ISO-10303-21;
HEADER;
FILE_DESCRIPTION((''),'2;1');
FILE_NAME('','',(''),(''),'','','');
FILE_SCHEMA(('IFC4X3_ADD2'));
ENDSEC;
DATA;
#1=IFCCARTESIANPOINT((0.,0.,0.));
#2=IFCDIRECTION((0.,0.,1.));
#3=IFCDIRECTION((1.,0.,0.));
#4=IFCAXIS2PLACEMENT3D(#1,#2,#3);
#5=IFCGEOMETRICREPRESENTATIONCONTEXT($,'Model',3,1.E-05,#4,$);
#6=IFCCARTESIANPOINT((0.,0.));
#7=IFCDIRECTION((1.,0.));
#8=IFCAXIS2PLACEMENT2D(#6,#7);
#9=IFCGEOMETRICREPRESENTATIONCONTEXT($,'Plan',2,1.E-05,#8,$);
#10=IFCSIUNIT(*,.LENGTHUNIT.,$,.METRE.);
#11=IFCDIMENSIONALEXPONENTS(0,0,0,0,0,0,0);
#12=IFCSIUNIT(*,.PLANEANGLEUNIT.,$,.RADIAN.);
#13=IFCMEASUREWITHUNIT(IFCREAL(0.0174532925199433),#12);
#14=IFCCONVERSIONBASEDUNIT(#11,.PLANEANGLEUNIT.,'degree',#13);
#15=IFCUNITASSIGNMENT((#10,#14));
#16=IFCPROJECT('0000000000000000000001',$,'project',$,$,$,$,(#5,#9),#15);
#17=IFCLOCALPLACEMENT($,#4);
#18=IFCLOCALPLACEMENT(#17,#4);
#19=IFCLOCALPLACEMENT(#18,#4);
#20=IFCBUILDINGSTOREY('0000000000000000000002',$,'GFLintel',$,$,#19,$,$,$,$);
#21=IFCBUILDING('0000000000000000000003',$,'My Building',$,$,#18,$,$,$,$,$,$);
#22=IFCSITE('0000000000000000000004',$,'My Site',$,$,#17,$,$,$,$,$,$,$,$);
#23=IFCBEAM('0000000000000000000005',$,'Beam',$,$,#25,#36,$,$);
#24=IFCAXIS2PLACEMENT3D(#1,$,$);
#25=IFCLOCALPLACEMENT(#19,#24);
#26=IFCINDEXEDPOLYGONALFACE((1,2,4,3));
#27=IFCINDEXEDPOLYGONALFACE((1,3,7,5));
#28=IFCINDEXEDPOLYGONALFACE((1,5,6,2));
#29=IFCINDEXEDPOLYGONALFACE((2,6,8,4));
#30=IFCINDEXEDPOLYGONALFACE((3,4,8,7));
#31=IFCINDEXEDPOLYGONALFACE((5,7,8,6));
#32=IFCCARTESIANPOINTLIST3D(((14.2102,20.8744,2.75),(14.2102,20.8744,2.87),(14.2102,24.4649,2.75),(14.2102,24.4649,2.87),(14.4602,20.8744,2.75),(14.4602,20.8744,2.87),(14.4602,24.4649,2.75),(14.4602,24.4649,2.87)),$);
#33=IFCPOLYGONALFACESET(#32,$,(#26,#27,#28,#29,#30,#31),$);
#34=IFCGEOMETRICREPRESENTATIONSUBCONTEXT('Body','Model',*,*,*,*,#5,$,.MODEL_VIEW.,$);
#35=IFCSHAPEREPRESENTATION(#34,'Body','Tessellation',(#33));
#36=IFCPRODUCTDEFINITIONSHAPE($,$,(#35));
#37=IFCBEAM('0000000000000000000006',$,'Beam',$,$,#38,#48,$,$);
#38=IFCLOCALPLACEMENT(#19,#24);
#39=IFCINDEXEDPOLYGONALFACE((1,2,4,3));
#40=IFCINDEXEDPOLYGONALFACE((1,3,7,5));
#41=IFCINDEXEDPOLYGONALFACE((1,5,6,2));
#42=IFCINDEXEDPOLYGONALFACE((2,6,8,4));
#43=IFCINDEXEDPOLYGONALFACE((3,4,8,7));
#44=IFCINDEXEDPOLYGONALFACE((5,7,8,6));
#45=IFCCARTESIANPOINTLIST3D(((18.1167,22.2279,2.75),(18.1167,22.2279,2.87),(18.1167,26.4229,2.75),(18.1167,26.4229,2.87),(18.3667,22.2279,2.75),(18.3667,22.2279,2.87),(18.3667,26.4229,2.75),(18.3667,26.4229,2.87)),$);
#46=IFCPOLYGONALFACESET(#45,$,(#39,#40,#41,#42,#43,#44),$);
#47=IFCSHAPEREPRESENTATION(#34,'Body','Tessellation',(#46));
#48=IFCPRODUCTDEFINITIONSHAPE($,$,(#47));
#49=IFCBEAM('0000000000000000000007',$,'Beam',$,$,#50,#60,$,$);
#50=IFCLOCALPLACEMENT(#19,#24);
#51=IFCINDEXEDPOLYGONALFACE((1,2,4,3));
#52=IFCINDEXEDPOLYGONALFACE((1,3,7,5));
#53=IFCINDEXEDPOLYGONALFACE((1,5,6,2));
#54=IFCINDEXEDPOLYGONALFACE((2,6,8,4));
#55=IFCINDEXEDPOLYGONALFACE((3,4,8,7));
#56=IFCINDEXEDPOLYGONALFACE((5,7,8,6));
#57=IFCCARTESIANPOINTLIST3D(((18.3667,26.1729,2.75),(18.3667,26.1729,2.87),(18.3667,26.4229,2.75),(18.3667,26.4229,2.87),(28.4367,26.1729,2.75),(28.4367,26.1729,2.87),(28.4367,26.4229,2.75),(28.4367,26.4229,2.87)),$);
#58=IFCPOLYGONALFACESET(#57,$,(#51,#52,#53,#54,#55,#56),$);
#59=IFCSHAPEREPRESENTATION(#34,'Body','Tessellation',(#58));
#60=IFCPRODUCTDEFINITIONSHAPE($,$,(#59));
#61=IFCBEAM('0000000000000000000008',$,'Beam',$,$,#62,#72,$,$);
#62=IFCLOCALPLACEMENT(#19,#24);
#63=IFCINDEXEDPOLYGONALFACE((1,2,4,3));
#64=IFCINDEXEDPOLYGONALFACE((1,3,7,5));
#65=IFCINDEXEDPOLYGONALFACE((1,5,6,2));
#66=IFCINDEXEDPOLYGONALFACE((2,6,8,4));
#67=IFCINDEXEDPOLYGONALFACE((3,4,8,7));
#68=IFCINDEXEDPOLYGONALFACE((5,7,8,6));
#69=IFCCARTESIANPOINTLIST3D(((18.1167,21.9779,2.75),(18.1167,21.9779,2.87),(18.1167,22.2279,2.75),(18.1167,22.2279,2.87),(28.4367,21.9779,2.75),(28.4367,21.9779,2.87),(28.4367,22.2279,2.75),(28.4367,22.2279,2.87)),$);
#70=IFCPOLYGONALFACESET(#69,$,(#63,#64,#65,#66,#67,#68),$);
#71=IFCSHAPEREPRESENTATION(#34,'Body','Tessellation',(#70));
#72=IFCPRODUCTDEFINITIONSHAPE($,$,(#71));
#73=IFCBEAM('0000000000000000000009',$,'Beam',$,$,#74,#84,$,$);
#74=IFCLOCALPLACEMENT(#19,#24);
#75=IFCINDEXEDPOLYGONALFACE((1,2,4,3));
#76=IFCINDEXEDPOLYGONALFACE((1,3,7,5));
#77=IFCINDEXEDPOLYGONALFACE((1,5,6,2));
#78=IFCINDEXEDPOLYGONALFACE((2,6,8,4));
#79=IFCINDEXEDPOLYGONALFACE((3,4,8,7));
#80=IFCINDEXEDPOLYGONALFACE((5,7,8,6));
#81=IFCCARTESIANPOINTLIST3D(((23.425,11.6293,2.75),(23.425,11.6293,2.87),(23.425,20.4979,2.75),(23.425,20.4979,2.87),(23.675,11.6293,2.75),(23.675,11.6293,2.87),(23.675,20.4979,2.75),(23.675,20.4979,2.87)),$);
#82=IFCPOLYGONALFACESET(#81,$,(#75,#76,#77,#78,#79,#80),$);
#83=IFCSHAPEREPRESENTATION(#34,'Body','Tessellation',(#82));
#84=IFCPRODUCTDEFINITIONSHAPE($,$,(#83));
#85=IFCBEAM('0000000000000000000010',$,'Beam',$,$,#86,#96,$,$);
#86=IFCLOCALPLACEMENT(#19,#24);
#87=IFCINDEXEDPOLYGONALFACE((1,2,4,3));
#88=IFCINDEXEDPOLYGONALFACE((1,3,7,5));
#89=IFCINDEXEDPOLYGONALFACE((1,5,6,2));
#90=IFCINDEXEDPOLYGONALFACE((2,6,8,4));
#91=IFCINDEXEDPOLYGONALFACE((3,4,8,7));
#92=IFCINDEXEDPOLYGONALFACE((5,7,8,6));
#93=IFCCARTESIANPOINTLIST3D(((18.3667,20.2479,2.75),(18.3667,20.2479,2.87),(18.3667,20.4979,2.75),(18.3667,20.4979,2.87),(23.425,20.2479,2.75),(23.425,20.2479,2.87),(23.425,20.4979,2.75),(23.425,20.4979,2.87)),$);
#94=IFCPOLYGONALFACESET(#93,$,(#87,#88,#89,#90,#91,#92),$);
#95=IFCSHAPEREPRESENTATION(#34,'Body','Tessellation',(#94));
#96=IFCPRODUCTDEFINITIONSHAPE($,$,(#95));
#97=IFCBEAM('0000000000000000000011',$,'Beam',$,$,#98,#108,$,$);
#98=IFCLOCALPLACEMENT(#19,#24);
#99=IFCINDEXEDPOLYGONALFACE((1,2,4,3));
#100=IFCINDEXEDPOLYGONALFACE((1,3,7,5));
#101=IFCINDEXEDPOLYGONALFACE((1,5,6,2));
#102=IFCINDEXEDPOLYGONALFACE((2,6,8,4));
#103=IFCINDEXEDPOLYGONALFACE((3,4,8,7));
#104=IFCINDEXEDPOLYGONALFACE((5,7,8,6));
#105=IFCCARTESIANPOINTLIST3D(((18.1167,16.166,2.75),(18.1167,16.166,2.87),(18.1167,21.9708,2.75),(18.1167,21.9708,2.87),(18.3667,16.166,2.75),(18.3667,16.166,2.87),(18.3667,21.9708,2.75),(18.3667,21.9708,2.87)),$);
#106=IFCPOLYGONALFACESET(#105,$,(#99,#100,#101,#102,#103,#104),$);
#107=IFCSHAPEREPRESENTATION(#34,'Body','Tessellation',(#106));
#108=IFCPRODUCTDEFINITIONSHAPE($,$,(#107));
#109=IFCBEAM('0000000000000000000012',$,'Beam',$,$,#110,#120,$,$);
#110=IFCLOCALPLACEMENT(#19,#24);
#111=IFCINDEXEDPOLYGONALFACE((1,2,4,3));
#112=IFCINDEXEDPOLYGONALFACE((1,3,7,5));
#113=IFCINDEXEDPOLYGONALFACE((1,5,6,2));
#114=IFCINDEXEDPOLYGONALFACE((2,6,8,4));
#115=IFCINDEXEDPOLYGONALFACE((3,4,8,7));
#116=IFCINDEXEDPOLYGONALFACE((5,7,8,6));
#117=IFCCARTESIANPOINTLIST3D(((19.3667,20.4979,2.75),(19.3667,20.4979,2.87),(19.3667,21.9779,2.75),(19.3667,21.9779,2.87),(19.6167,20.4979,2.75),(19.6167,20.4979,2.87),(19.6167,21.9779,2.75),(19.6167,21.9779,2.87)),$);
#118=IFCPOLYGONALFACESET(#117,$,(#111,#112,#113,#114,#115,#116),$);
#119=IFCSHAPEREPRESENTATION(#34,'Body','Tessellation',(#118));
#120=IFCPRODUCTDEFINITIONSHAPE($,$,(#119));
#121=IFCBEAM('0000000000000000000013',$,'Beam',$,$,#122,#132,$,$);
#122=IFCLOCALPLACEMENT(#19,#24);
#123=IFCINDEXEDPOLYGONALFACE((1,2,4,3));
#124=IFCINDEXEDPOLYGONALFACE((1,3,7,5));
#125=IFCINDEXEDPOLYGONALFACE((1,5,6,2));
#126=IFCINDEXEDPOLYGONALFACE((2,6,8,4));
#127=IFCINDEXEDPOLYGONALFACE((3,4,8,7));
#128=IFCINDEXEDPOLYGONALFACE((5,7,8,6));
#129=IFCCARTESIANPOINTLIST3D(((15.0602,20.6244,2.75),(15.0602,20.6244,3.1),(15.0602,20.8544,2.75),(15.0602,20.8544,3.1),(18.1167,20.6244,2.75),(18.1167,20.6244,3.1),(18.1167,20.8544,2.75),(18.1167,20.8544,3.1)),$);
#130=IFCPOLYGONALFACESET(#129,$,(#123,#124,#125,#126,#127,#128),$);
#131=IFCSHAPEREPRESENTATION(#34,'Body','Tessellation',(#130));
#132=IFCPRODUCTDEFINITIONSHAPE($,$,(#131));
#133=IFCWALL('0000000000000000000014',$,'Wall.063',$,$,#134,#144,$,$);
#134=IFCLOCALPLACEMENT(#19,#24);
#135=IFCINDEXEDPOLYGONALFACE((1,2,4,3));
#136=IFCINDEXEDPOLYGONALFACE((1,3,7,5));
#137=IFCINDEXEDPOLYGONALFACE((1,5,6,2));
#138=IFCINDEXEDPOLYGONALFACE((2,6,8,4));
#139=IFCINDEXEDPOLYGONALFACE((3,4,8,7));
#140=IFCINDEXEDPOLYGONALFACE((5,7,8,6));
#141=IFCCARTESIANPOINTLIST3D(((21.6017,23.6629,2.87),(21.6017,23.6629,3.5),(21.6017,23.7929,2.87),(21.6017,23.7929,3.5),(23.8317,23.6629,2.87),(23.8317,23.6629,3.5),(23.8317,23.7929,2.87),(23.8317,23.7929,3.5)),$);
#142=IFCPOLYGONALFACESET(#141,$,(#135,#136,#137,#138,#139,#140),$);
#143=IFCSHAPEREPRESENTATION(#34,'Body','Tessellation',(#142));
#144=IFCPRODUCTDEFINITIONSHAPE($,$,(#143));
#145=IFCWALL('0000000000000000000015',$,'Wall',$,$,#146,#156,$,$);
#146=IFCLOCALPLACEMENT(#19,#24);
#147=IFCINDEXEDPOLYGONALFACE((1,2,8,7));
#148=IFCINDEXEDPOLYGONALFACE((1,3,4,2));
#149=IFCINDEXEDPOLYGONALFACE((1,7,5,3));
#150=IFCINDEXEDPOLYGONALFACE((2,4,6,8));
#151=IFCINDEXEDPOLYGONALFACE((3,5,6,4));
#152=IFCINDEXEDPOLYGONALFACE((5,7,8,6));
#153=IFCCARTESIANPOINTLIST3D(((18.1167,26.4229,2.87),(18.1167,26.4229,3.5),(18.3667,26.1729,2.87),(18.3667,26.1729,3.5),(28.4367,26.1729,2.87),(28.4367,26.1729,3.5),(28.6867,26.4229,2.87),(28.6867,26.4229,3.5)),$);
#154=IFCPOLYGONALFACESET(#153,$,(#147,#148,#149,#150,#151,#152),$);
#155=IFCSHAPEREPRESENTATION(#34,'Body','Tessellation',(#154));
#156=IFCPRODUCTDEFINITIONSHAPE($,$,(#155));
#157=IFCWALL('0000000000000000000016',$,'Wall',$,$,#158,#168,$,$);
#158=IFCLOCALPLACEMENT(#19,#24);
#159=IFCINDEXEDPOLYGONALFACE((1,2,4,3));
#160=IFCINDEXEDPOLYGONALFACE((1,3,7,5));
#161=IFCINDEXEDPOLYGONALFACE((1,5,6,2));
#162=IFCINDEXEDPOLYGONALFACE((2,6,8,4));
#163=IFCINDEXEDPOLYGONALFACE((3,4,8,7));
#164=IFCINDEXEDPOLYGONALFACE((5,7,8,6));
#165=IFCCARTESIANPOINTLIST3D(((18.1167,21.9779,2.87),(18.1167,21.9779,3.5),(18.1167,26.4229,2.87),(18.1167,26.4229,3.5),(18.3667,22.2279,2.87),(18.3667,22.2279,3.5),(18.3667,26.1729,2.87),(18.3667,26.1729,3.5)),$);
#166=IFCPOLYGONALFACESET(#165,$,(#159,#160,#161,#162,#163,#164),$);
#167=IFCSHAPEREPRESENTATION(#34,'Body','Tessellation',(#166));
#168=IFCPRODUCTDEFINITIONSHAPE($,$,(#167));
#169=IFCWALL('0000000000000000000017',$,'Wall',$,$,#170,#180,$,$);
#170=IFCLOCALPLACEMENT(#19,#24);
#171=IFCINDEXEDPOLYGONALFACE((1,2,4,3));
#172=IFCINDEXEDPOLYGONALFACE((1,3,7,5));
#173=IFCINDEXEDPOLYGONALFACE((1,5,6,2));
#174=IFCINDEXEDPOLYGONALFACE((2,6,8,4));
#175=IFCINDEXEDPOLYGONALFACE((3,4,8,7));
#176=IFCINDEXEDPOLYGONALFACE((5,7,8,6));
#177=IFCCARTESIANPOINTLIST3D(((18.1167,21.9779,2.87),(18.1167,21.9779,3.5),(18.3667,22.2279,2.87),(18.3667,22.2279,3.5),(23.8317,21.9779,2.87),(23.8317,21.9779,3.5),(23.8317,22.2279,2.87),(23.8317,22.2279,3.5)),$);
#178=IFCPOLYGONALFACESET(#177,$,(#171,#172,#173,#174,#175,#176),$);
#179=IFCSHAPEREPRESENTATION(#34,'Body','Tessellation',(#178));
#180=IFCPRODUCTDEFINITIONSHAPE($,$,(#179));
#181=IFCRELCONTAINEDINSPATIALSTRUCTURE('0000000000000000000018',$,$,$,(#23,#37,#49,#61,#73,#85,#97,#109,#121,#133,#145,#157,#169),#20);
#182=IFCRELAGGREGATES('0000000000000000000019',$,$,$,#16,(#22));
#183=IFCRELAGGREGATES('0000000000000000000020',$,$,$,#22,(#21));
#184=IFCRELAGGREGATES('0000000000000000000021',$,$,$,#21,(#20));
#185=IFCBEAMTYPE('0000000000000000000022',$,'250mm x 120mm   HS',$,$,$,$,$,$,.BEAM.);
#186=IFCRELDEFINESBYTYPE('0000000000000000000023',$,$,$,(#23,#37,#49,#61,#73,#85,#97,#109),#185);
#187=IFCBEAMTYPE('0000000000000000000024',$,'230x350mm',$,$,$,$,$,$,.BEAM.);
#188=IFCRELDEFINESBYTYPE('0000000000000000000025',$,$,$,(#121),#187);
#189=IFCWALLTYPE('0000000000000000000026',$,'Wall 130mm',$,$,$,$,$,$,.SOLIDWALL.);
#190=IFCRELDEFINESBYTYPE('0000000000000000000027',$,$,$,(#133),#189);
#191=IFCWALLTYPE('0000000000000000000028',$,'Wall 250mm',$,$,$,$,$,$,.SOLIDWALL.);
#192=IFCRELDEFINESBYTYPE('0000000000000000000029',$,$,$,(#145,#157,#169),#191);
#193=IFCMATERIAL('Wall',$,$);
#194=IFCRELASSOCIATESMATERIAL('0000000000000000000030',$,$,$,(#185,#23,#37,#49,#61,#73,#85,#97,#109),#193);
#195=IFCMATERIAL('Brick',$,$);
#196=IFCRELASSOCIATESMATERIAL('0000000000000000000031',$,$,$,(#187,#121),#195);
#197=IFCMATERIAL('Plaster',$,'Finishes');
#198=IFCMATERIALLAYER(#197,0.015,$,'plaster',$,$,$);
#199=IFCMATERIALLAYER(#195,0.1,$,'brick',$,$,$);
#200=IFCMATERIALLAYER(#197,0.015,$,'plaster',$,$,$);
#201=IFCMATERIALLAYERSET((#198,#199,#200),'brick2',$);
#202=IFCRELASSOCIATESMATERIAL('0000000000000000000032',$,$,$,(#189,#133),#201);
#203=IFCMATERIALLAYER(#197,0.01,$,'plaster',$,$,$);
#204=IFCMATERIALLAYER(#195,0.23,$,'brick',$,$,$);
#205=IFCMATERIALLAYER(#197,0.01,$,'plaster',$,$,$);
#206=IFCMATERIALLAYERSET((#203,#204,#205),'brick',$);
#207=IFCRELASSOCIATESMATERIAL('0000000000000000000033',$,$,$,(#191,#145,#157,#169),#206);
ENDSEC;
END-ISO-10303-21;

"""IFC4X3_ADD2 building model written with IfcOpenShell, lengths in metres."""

from ifc_helpers import new_model, entity, si_unit, converted_unit, frame, origin_with_axes, origin_2d_with_axis, place, context, subcontext, project, spatial, line, indexed_curve, rectangle, outline, extrude, material, layer, layer_set, layer_usage, material_profile, profile_set, profile_usage, type_object, element, save


model = new_model("IFC4X3_ADD2")

# Units and contexts
model_context = context("Model", 3, precision=1e-05, world=origin_with_axes())
plan_context = context("Plan", 2, precision=1e-05, world=origin_2d_with_axis())
body_context = subcontext(model_context, "Body", "Model", "MODEL_VIEW")
ifc_project = project(units=[si_unit("LENGTHUNIT", "METRE"), converted_unit("PLANEANGLEUNIT", "degree", entity("IfcReal", 0.0174532925199433), si_unit("PLANEANGLEUNIT", "RADIAN"), dimensions=[0, 0, 0, 0, 0, 0, 0])], contexts=[model_context, plan_context])

# Site, building, storey
site_placement = place(None, origin_with_axes())
site = spatial("IfcSite", under=ifc_project, at=site_placement, Name="My Site")
building_placement = place(site_placement, origin_with_axes())
building = spatial("IfcBuilding", under=site, at=building_placement, Name="My Building")
storey_placement = place(building_placement, origin_with_axes())
storey = spatial("IfcBuildingStorey", under=building, at=storey_placement, Name="GFLintel")

# Beams
ifc_material_1 = material(Name="Wall")
ifc_material_profile_1 = material_profile(ifc_material_1, rectangle(XDim=0.25, YDim=0.12))
ifc_profile_set_1 = profile_set([ifc_material_profile_1], Name="concrete")
ifc_profile_usage_1 = profile_usage(ifc_profile_set_1, cardinal=5)
beam_type_1 = type_object("IfcBeamType", Name="250mm x 120mm   HS", PredefinedType="BEAM", material=ifc_profile_set_1)
beam_1_placement = place(storey_placement, frame((14.3352, 24.4649, 2.81), z_axis=(0.0, -1.0, 0.0), x_axis=(1.0, 0.0, 0.0)))
element("IfcBeam", 1, at=beam_1_placement, inside=storey, type_object=beam_type_1, material=ifc_profile_usage_1, Name="Beam", context=body_context, shape_type="SweptSolid", body=[
    extrude(rectangle(XDim=0.25, YDim=0.12), origin_with_axes(), (0.0, 0.0, 1.0), 3.5905),
])
ifc_profile_usage_2 = profile_usage(ifc_profile_set_1, cardinal=5)
beam_2_placement = place(storey_placement, frame((18.2417, 26.4229, 2.81), z_axis=(0.0, -1.0, 0.0), x_axis=(1.0, 0.0, 0.0)))
element("IfcBeam", 2, at=beam_2_placement, inside=storey, type_object=beam_type_1, material=ifc_profile_usage_2, Name="Beam", context=body_context, shape_type="SweptSolid", body=[
    extrude(rectangle(XDim=0.25, YDim=0.12), origin_with_axes(), (0.0, 0.0, 1.0), 4.195),
])
ifc_profile_usage_3 = profile_usage(ifc_profile_set_1, cardinal=5)
beam_3_placement = place(storey_placement, frame((18.3667, 26.2979, 2.81), z_axis=(1.0, 0.0, 0.0), x_axis=(0.0, 1.0, 0.0)))
element("IfcBeam", 3, at=beam_3_placement, inside=storey, type_object=beam_type_1, material=ifc_profile_usage_3, Name="Beam", context=body_context, shape_type="SweptSolid", body=[
    extrude(rectangle(XDim=0.25, YDim=0.12), origin_with_axes(), (0.0, 0.0, 1.0), 10.07),
])
ifc_profile_usage_4 = profile_usage(ifc_profile_set_1, cardinal=5)
beam_4_placement = place(storey_placement, frame((18.1167, 22.1029, 2.81), z_axis=(1.0, 0.0, 0.0), x_axis=(0.0, 1.0, 0.0)))
element("IfcBeam", 4, at=beam_4_placement, inside=storey, type_object=beam_type_1, material=ifc_profile_usage_4, Name="Beam", context=body_context, shape_type="SweptSolid", body=[
    extrude(rectangle(XDim=0.25, YDim=0.12), origin_with_axes(), (0.0, 0.0, 1.0), 10.32),
])
ifc_profile_usage_5 = profile_usage(ifc_profile_set_1, cardinal=5)
beam_5_placement = place(storey_placement, frame((23.55, 20.4979, 2.81), z_axis=(0.0, -1.0, 0.0), x_axis=(1.0, 0.0, 0.0)))
element("IfcBeam", 5, at=beam_5_placement, inside=storey, type_object=beam_type_1, material=ifc_profile_usage_5, Name="Beam", context=body_context, shape_type="SweptSolid", body=[
    extrude(rectangle(XDim=0.25, YDim=0.12), origin_with_axes(), (0.0, 0.0, 1.0), 8.8685),
])
ifc_profile_usage_6 = profile_usage(ifc_profile_set_1, cardinal=5)
beam_6_placement = place(storey_placement, frame((18.3667, 20.3729, 2.81), z_axis=(1.0, 0.0, 0.0), x_axis=(0.0, 1.0, 0.0)))
element("IfcBeam", 6, at=beam_6_placement, inside=storey, type_object=beam_type_1, material=ifc_profile_usage_6, Name="Beam", context=body_context, shape_type="SweptSolid", body=[
    extrude(rectangle(XDim=0.25, YDim=0.12), origin_with_axes(), (0.0, 0.0, 1.0), 5.0583),
])
ifc_profile_usage_7 = profile_usage(ifc_profile_set_1, cardinal=5)
beam_7_placement = place(storey_placement, frame((18.2417, 21.9708, 2.81), z_axis=(0.0, -1.0, 0.0), x_axis=(1.0, 0.0, 0.0)))
element("IfcBeam", 7, at=beam_7_placement, inside=storey, type_object=beam_type_1, material=ifc_profile_usage_7, Name="Beam", context=body_context, shape_type="SweptSolid", body=[
    extrude(rectangle(XDim=0.25, YDim=0.12), origin_with_axes(), (0.0, 0.0, 1.0), 5.8048),
])
ifc_profile_usage_8 = profile_usage(ifc_profile_set_1, cardinal=5)
beam_8_placement = place(storey_placement, frame((19.4917, 21.9779, 2.81), z_axis=(0.0, -1.0, 0.0), x_axis=(1.0, 0.0, 0.0)))
element("IfcBeam", 8, at=beam_8_placement, inside=storey, type_object=beam_type_1, material=ifc_profile_usage_8, Name="Beam", context=body_context, shape_type="SweptSolid", body=[
    extrude(rectangle(XDim=0.25, YDim=0.12), origin_with_axes(), (0.0, 0.0, 1.0), 1.48),
])
ifc_material_2 = material(Name="Brick")
ifc_material_profile_2 = material_profile(ifc_material_2, rectangle(XDim=0.23, YDim=0.35))
ifc_profile_set_2 = profile_set([ifc_material_profile_2], Name="stone")
ifc_profile_usage_9 = profile_usage(ifc_profile_set_2)
beam_type_2 = type_object("IfcBeamType", Name="230x350mm", PredefinedType="BEAM", material=ifc_profile_set_2)
beam_9_placement = place(storey_placement, frame((18.1167, 20.7394, 2.925), z_axis=(-1.0, 0.0, 0.0), x_axis=(0.0, -1.0, 0.0)))
element("IfcBeam", 9, at=beam_9_placement, inside=storey, type_object=beam_type_2, material=ifc_profile_usage_9, Name="Beam", context=body_context, shape_type="SweptSolid", body=[
    extrude(rectangle(XDim=0.23, YDim=0.35), origin_with_axes(), (0.0, 0.0, 1.0), 3.0565),
])

# Walls
ifc_material_3 = material(Name="Plaster", Category="Finishes")
ifc_layer_1 = layer(ifc_material_3, 0.015, Name="plaster")
ifc_layer_2 = layer(ifc_material_2, 0.1, Name="brick")
ifc_layer_3 = layer(ifc_material_3, 0.015, Name="plaster")
ifc_layer_set_1 = layer_set([ifc_layer_1, ifc_layer_2, ifc_layer_3], Name="brick2")
ifc_layer_usage_1 = layer_usage(ifc_layer_set_1, "AXIS2", "POSITIVE", 0.0)
wall_type_1 = type_object("IfcWallType", Name="Wall 130mm", PredefinedType="SOLIDWALL", material=ifc_layer_set_1)
wall_1_placement = place(storey_placement, frame((21.6017, 23.6629, 2.87), z_axis=(0.0, 0.0, 1.0), x_axis=(1.0, 0.0, 0.0)))
element("IfcWall", 10, at=wall_1_placement, inside=storey, type_object=wall_type_1, material=ifc_layer_usage_1, Name="Wall.063", context=body_context, shape_type="SweptSolid", body=[
    extrude(outline(indexed_curve([(0.0, 0.0), (0.0, 0.13), (2.23, 0.13), (2.23, 0.0)], segments=[line(1, 2, 3, 4, 1)])), origin_with_axes(), (0.0, 0.0, 1.0), 0.63),
])
ifc_layer_4 = layer(ifc_material_3, 0.01, Name="plaster")
ifc_layer_5 = layer(ifc_material_2, 0.23, Name="brick")
ifc_layer_6 = layer(ifc_material_3, 0.01, Name="plaster")
ifc_layer_set_2 = layer_set([ifc_layer_4, ifc_layer_5, ifc_layer_6], Name="brick")
wall_type_2 = type_object("IfcWallType", Name="Wall 250mm", PredefinedType="SOLIDWALL", material=ifc_layer_set_2)
ifc_layer_usage_2 = layer_usage(ifc_layer_set_2, "AXIS2", "POSITIVE", 0.0)
wall_2_placement = place(storey_placement, frame((18.3667, 26.1729, 2.87), z_axis=(0.0, 0.0, 1.0), x_axis=(1.0, 0.0, 0.0)))
element("IfcWall", 11, at=wall_2_placement, inside=storey, type_object=wall_type_2, material=ifc_layer_usage_2, Name="Wall", context=body_context, shape_type="SweptSolid", body=[
    extrude(outline(indexed_curve([(0.0, 0.0), (-0.25, 0.25), (10.32, 0.25), (10.07, 0.0)], segments=[line(1, 2, 3, 4, 1)])), origin_with_axes(), (0.0, 0.0, 1.0), 0.63),
])
ifc_layer_usage_3 = layer_usage(ifc_layer_set_2, "AXIS2", "POSITIVE", 0.0)
wall_3_placement = place(storey_placement, frame((18.3667, 21.9779, 2.87), z_axis=(0.0, 0.0, 1.0), x_axis=(0.0, 1.0, 0.0)))
element("IfcWall", 12, at=wall_3_placement, inside=storey, type_object=wall_type_2, material=ifc_layer_usage_3, Name="Wall", context=body_context, shape_type="SweptSolid", body=[
    extrude(outline(indexed_curve([(0.25, 0.0), (0.0, 0.25), (4.445, 0.25), (4.195, 0.0)], segments=[line(1, 2, 3, 4, 1)])), origin_with_axes(), (0.0, 0.0, 1.0), 0.63),
])
ifc_layer_usage_4 = layer_usage(ifc_layer_set_2, "AXIS2", "POSITIVE", 0.0)
wall_4_placement = place(storey_placement, frame((18.3667, 21.9779, 2.87), z_axis=(0.0, 0.0, 1.0), x_axis=(1.0, 0.0, 0.0)))
element("IfcWall", 13, at=wall_4_placement, inside=storey, type_object=wall_type_2, material=ifc_layer_usage_4, Name="Wall", context=body_context, shape_type="SweptSolid", body=[
    extrude(outline(indexed_curve([(-0.25, 0.0), (0.0, 0.25), (5.465, 0.25), (5.465, 0.0)], segments=[line(1, 2, 3, 4, 1)])), origin_with_axes(), (0.0, 0.0, 1.0), 0.63),
])

save(model, "model.ifc")
